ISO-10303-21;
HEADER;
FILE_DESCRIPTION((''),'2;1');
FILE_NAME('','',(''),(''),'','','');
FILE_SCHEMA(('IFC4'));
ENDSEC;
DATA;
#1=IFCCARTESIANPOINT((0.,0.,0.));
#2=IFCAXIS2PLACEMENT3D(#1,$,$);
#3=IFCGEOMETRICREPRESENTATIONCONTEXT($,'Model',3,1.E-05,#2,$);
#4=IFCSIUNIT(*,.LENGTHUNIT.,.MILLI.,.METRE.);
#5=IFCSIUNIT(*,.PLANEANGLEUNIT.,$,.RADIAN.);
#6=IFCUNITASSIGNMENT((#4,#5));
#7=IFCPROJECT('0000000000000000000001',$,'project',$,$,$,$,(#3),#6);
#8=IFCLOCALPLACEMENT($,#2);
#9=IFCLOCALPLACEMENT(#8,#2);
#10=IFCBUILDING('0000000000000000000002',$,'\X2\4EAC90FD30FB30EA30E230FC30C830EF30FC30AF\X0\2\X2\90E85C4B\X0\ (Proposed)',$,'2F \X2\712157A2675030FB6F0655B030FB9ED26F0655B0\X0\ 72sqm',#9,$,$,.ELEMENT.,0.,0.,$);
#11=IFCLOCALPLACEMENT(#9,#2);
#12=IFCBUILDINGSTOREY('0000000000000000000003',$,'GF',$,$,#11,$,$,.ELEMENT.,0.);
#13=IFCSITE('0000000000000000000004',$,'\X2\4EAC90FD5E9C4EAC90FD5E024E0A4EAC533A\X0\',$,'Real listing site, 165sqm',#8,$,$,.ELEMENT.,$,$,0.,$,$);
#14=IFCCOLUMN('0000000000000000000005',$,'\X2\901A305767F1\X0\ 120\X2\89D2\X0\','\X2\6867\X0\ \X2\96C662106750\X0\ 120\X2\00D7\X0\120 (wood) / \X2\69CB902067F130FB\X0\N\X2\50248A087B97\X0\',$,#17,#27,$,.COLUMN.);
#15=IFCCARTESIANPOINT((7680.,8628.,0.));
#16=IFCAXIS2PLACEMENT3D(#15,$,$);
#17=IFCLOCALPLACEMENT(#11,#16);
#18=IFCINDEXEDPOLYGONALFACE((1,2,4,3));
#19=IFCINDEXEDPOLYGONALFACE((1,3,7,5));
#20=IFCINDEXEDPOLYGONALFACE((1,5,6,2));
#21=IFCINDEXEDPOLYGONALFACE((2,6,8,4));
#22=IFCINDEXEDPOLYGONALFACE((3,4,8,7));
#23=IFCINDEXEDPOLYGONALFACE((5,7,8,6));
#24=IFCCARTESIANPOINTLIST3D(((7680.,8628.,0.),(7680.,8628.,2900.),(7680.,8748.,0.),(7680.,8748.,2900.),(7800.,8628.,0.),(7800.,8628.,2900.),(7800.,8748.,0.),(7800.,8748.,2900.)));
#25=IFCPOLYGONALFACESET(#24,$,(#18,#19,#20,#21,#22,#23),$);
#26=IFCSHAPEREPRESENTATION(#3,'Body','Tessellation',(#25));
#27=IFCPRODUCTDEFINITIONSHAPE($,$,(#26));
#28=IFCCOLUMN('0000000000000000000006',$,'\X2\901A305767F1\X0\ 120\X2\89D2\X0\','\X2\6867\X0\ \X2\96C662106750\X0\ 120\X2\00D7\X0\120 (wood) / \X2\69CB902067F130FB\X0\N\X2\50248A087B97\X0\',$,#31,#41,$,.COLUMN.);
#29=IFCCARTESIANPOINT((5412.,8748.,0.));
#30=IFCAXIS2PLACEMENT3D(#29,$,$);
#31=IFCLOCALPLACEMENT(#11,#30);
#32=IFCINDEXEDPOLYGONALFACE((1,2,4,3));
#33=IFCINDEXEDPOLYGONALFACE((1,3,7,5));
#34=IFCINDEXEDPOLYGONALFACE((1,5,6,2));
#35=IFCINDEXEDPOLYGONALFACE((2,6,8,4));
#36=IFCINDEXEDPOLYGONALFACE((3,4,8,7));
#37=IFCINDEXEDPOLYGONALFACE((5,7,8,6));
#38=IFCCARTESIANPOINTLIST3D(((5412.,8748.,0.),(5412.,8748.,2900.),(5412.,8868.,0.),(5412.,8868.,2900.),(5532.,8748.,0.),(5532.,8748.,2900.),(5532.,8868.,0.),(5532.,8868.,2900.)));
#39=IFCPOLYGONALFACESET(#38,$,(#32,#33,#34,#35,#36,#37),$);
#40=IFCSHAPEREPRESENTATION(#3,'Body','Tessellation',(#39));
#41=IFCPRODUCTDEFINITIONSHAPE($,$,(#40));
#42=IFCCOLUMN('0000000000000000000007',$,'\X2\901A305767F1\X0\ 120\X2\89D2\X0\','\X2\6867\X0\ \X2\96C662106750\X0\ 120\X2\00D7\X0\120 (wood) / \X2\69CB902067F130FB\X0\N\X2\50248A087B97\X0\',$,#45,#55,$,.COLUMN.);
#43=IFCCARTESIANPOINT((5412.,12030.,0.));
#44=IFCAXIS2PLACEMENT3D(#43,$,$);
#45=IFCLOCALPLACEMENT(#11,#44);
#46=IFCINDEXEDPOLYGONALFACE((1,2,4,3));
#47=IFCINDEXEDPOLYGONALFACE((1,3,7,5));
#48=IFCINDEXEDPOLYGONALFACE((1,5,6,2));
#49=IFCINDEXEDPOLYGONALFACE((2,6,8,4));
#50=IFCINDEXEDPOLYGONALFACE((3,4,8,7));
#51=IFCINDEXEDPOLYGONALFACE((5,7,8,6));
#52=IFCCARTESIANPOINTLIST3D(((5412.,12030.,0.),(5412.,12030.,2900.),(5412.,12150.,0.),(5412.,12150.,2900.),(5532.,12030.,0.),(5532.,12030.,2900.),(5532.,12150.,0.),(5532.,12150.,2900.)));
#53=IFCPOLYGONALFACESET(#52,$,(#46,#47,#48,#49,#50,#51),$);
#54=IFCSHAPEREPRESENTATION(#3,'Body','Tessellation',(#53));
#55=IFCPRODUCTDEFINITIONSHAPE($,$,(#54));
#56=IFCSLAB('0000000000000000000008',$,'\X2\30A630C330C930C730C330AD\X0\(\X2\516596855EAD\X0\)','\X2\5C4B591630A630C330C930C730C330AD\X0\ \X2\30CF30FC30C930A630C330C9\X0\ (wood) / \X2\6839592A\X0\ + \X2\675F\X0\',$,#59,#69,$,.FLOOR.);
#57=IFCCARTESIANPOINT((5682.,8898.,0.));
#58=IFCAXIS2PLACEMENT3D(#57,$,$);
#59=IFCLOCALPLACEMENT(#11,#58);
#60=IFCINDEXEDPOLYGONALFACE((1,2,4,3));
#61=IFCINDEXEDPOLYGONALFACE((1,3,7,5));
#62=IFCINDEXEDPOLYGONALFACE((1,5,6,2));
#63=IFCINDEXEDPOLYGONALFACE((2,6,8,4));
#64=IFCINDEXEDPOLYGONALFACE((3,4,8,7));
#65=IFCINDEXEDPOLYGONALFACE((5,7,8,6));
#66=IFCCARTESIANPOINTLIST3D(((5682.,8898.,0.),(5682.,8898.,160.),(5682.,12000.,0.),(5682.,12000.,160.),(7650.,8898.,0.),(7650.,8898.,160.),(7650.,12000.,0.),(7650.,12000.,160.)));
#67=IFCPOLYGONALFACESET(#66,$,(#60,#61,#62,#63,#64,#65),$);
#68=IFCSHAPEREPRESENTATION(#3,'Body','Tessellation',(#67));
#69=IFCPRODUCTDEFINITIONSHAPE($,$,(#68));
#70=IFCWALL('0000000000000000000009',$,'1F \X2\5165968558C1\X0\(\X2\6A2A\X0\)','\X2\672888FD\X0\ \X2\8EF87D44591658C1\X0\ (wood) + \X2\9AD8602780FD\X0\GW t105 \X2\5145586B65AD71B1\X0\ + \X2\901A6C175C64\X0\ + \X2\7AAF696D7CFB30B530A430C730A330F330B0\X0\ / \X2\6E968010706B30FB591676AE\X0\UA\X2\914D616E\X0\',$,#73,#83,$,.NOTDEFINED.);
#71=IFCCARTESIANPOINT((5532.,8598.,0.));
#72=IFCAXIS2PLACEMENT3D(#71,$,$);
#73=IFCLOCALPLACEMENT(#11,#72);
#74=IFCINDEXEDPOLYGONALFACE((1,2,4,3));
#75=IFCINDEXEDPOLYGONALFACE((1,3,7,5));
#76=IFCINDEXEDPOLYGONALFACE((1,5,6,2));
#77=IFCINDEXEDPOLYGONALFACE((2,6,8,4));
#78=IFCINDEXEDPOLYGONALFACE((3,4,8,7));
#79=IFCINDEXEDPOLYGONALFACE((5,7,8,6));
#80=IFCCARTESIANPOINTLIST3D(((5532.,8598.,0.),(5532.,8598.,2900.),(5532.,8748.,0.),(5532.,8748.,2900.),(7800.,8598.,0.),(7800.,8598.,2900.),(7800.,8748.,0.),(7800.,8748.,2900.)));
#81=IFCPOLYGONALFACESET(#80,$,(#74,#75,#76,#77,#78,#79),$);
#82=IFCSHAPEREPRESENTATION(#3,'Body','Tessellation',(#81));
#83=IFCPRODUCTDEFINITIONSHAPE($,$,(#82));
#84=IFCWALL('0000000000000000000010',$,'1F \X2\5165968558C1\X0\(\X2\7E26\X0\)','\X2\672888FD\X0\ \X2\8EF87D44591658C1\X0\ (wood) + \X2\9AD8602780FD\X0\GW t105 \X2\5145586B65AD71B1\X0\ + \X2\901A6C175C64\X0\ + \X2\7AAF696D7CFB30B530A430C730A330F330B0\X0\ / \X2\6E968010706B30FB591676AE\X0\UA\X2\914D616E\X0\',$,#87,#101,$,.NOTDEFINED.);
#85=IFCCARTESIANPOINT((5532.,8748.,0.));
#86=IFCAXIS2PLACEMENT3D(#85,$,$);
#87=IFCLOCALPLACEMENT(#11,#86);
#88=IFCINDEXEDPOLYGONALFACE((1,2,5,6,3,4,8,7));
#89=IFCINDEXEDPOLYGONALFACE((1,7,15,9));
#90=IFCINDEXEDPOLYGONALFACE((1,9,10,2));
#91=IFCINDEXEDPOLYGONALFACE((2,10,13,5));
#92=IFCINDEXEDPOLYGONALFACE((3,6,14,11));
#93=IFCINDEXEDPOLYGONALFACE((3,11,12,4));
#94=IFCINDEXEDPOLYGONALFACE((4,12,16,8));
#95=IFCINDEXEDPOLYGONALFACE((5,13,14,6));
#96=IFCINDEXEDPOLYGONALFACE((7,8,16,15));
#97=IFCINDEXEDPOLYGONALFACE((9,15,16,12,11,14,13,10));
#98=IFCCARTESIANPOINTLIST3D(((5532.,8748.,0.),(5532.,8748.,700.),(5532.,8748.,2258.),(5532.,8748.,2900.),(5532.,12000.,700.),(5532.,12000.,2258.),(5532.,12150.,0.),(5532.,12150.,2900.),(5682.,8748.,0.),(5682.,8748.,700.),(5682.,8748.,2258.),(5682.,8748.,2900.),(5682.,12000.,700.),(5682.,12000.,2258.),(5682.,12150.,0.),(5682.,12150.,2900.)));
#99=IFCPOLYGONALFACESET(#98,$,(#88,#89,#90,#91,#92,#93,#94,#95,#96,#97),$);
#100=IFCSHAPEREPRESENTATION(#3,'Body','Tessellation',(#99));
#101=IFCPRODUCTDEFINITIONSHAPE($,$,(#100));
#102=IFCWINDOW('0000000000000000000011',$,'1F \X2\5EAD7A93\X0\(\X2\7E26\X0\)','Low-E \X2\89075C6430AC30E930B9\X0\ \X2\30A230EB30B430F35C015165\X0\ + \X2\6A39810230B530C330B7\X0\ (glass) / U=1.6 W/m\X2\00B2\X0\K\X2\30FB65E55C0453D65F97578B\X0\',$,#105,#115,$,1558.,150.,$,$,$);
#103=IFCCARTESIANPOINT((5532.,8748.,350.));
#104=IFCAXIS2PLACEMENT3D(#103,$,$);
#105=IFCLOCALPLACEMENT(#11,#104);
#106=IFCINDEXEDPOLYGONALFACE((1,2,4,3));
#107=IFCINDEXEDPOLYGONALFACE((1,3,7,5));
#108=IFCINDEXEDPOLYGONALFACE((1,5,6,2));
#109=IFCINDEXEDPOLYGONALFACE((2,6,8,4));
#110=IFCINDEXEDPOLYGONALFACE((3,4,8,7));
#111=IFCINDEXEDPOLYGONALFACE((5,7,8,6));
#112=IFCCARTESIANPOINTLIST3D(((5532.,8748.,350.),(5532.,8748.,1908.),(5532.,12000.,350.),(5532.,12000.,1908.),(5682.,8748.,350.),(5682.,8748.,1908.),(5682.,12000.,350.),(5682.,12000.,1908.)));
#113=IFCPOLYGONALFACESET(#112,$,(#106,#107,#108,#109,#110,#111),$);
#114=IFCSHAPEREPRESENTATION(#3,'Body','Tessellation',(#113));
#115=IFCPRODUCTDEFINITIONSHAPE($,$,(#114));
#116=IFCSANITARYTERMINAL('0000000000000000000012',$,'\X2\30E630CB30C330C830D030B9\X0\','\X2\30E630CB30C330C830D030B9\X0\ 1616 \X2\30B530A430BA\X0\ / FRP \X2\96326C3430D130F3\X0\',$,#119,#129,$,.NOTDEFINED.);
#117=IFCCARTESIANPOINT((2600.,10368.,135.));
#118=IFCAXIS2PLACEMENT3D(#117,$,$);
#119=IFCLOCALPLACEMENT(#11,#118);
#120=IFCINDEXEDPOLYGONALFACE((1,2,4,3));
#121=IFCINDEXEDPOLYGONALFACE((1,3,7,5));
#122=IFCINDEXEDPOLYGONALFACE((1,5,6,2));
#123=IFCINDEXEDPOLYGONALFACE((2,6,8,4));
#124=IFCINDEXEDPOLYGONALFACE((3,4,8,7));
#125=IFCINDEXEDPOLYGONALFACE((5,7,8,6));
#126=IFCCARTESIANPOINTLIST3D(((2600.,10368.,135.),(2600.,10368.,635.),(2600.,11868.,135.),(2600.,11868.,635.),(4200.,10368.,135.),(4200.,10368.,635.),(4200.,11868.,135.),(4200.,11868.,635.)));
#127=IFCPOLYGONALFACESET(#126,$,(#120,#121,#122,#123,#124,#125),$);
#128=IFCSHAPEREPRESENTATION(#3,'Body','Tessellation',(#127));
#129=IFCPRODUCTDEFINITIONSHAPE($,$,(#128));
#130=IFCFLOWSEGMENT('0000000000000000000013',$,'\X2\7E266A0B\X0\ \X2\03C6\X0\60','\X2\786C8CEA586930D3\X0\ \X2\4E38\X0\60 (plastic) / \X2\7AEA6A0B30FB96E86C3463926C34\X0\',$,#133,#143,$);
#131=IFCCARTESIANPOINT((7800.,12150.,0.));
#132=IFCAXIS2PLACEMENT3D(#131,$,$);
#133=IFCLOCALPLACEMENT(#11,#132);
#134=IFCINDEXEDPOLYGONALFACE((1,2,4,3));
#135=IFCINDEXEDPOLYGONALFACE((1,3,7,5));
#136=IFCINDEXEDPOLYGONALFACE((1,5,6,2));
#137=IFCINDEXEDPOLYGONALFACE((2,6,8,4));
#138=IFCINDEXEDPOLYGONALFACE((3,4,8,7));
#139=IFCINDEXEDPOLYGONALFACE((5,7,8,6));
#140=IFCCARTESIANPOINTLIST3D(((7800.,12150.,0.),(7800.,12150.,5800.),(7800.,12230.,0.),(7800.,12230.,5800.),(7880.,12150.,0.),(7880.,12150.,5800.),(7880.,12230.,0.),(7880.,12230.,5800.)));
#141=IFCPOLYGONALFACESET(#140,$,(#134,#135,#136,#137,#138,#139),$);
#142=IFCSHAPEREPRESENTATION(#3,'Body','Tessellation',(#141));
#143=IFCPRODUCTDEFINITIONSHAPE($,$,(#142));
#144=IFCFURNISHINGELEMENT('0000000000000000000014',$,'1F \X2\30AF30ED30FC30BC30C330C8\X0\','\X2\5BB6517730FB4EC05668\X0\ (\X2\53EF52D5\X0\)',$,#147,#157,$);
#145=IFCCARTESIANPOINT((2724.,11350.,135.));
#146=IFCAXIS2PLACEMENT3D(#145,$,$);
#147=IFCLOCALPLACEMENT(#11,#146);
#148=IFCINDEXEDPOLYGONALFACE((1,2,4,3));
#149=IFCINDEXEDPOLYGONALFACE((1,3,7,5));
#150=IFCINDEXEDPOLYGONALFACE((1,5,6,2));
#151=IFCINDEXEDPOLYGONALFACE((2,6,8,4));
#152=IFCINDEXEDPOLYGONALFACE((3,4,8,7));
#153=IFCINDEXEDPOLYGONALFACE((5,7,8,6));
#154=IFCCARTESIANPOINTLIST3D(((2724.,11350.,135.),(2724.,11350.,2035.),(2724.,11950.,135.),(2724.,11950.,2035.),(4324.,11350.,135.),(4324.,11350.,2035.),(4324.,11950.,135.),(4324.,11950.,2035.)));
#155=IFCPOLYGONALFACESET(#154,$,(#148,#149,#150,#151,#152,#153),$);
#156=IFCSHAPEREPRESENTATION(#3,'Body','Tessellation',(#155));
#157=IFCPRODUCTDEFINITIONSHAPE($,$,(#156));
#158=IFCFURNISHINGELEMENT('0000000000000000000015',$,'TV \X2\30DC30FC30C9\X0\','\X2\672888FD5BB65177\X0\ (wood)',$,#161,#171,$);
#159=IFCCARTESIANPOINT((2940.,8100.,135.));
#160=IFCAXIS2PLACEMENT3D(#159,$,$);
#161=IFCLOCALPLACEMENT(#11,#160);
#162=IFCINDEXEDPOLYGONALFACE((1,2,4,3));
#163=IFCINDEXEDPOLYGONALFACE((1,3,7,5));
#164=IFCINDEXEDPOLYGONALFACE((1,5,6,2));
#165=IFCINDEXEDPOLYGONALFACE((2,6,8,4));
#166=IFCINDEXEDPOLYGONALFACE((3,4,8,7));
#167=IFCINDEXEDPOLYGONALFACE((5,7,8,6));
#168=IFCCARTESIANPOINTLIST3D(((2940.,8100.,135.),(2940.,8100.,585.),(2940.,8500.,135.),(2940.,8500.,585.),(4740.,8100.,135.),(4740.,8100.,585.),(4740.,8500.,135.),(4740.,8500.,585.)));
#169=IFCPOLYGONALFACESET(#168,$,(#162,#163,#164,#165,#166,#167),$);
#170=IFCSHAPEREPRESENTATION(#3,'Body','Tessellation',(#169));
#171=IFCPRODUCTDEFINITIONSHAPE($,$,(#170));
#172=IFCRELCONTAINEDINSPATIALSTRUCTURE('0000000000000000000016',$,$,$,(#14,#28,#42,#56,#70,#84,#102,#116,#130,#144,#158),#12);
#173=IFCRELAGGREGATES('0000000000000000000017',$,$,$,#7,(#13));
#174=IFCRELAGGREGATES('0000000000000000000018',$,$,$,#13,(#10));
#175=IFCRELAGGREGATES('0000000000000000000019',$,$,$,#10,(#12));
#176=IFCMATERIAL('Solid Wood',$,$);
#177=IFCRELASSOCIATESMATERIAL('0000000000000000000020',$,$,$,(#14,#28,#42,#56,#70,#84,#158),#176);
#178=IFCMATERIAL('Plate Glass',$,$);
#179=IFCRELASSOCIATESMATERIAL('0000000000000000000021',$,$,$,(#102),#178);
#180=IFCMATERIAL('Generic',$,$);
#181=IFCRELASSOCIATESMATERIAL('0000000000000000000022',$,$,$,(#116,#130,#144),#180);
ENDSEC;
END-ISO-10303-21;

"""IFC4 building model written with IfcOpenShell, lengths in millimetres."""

from ifc_helpers import new_model, si_unit, frame, frame_2d, origin, place, context, project, spatial, rectangle, extrude, material, element, fill, save


model = new_model("IFC4")

# Units and contexts
model_context = context("Model", 3, precision=1e-05, world=origin())
ifc_project = project(units=[si_unit("LENGTHUNIT", "METRE", prefix="MILLI"), si_unit("PLANEANGLEUNIT", "RADIAN")], contexts=[model_context])

# Site, building, storey
site_placement = place(None, origin())
site = spatial("IfcSite", under=ifc_project, at=site_placement, Name="京都府京都市上京区", ObjectType="Real listing site, 165sqm", CompositionType="ELEMENT", RefElevation=0.0)
building_placement = place(site_placement, origin())
building = spatial("IfcBuilding", under=site, at=building_placement, Name="京都・リモートワーク2部屋 (Proposed)", ObjectType="2F 無垢材・漆喰・黒漆喰 72sqm", CompositionType="ELEMENT", ElevationOfRefHeight=0.0, ElevationOfTerrain=0.0)
storey_placement = place(building_placement, origin())
storey = spatial("IfcBuildingStorey", under=building, at=storey_placement, Name="GF", CompositionType="ELEMENT", Elevation=0.0)

# Columns
ifc_material_1 = material(Name="Solid Wood")
column_1_placement = place(storey_placement, frame((7680.0, 8628.0, 0.0)))
element("IfcColumn", 1, at=column_1_placement, inside=storey, material=ifc_material_1, Name="通し柱 120角", Description="桧 集成材 120×120 (wood) / 構造柱・N値計算", PredefinedType="COLUMN", context=model_context, shape_type="SweptSolid", body=[
    extrude(rectangle(XDim=120.0, YDim=120.0, at=frame_2d((60.0, 60.0))), frame((7680.0, 8628.0, 0.0)), (0.0, 0.0, 1.0), 2900.0),
])
column_2_placement = place(storey_placement, frame((5412.0, 8748.0, 0.0)))
element("IfcColumn", 2, at=column_2_placement, inside=storey, material=ifc_material_1, Name="通し柱 120角", Description="桧 集成材 120×120 (wood) / 構造柱・N値計算", PredefinedType="COLUMN", context=model_context, shape_type="SweptSolid", body=[
    extrude(rectangle(XDim=120.0, YDim=120.0, at=frame_2d((60.0, 60.0))), frame((5412.0, 8748.0, 0.0)), (0.0, 0.0, 1.0), 2900.0),
])
column_3_placement = place(storey_placement, frame((5412.0, 12030.0, 0.0)))
element("IfcColumn", 3, at=column_3_placement, inside=storey, material=ifc_material_1, Name="通し柱 120角", Description="桧 集成材 120×120 (wood) / 構造柱・N値計算", PredefinedType="COLUMN", context=model_context, shape_type="SweptSolid", body=[
    extrude(rectangle(XDim=120.0, YDim=120.0, at=frame_2d((60.0, 60.0))), frame((5412.0, 12030.0, 0.0)), (0.0, 0.0, 1.0), 2900.0),
])

# Slab
slab_placement = place(storey_placement, frame((5682.0, 8898.0, 0.0)))
element("IfcSlab", 4, at=slab_placement, inside=storey, material=ifc_material_1, Name="ウッドデッキ(入隅庭)", Description="屋外ウッドデッキ ハードウッド (wood) / 根太 + 束", PredefinedType="FLOOR", context=model_context, shape_type="SweptSolid", body=[
    extrude(rectangle(XDim=1968.0, YDim=3102.0, at=frame_2d((984.0, 1551.0))), frame((5682.0, 8898.0, 0.0)), (0.0, 0.0, 1.0), 160.0),
])

# Wall
wall_1_placement = place(storey_placement, frame((5532.0, 8598.0, 0.0)))
element("IfcWall", 5, at=wall_1_placement, inside=storey, material=ifc_material_1, Name="1F 入隅壁(横)", Description="木製 軸組外壁 (wood) + 高性能GW t105 充填断熱 + 通気層 + 窯業系サイディング / 準耐火・外皮UA配慮", PredefinedType="NOTDEFINED", context=model_context, shape_type="SweptSolid", body=[
    extrude(rectangle(XDim=2268.0, YDim=150.0, at=frame_2d((1134.0, 75.0))), frame((5532.0, 8598.0, 0.0)), (0.0, 0.0, 1.0), 2900.0),
])

# Wall, opening, window
wall_2_placement = place(storey_placement, frame((5532.0, 8748.0, 0.0)))
wall_2 = element("IfcWall", 6, at=wall_2_placement, inside=storey, material=ifc_material_1, Name="1F 入隅壁(縦)", Description="木製 軸組外壁 (wood) + 高性能GW t105 充填断熱 + 通気層 + 窯業系サイディング / 準耐火・外皮UA配慮", PredefinedType="NOTDEFINED", context=model_context, shape_type="SweptSolid", body=[
    extrude(rectangle(XDim=150.0, YDim=3402.0, at=frame_2d((75.0, 1701.0))), frame((5532.0, 8748.0, 0.0)), (0.0, 0.0, 1.0), 2900.0),
])
opening_placement = place(storey_placement, frame((5532.0, 8748.0, 350.0)))
opening = element("IfcOpeningElement", 7, at=opening_placement, cuts=wall_2, PredefinedType="NOTDEFINED", context=model_context, shape_type="SweptSolid", body=[
    extrude(rectangle(XDim=150.0, YDim=3252.0, at=frame_2d((75.0, 1626.0))), frame((5532.0, 8748.0, 350.0)), (0.0, 0.0, 1.0), 1558.0),
])
ifc_material_2 = material(Name="Plate Glass")
window_placement = place(storey_placement, frame((5532.0, 8748.0, 350.0)))
window = element("IfcWindow", 8, at=window_placement, inside=storey, material=ifc_material_2, Name="1F 庭窓(縦)", Description="Low-E 複層ガラス アルゴン封入 + 樹脂サッシ (glass) / U=1.6 W/m²K・日射取得型", OverallHeight=1558.0, OverallWidth=150.0, context=model_context, shape_type="SweptSolid", body=[
    extrude(rectangle(XDim=150.0, YDim=3252.0, at=frame_2d((75.0, 1626.0))), frame((5532.0, 8748.0, 350.0)), (0.0, 0.0, 1.0), 1558.0),
])
fill(opening, window)

# Sanitary terminal
ifc_material_3 = material(Name="Generic")
sanitary_terminal_placement = place(storey_placement, frame((2600.0, 10368.0, 135.0)))
element("IfcSanitaryTerminal", 9, at=sanitary_terminal_placement, inside=storey, material=ifc_material_3, Name="ユニットバス", Description="ユニットバス 1616 サイズ / FRP 防水パン", PredefinedType="NOTDEFINED", context=model_context, shape_type="SweptSolid", body=[
    extrude(rectangle(XDim=1600.0, YDim=1500.0, at=frame_2d((800.0, 750.0))), frame((2600.0, 10368.0, 135.0)), (0.0, 0.0, 1.0), 500.0),
])

# Flow segment
flow_segment_placement = place(storey_placement, frame((7800.0, 12150.0, 0.0)))
element("IfcFlowSegment", 10, at=flow_segment_placement, inside=storey, material=ifc_material_3, Name="縦樋 φ60", Description="硬質塩ビ 丸60 (plastic) / 竪樋・雨水排水", context=model_context, shape_type="SweptSolid", body=[
    extrude(rectangle(XDim=80.0, YDim=80.0, at=frame_2d((40.0, 40.0))), frame((7800.0, 12150.0, 0.0)), (0.0, 0.0, 1.0), 5800.0),
])

# Furnishing elements
furnishing_1_placement = place(storey_placement, frame((2724.0, 11350.0, 135.0)))
element("IfcFurnishingElement", 11, at=furnishing_1_placement, inside=storey, material=ifc_material_3, Name="1F クローゼット", Description="家具・什器 (可動)", context=model_context, shape_type="SweptSolid", body=[
    extrude(rectangle(XDim=1600.0, YDim=600.0, at=frame_2d((800.0, 300.0))), frame((2724.0, 11350.0, 135.0)), (0.0, 0.0, 1.0), 1900.0),
])
furnishing_2_placement = place(storey_placement, frame((2940.0, 8100.0, 135.0)))
element("IfcFurnishingElement", 12, at=furnishing_2_placement, inside=storey, material=ifc_material_1, Name="TV ボード", Description="木製家具 (wood)", context=model_context, shape_type="SweptSolid", body=[
    extrude(rectangle(XDim=1800.0, YDim=400.0, at=frame_2d((900.0, 200.0))), frame((2940.0, 8100.0, 135.0)), (0.0, 0.0, 1.0), 450.0),
])

save(model, "model.ifc")
